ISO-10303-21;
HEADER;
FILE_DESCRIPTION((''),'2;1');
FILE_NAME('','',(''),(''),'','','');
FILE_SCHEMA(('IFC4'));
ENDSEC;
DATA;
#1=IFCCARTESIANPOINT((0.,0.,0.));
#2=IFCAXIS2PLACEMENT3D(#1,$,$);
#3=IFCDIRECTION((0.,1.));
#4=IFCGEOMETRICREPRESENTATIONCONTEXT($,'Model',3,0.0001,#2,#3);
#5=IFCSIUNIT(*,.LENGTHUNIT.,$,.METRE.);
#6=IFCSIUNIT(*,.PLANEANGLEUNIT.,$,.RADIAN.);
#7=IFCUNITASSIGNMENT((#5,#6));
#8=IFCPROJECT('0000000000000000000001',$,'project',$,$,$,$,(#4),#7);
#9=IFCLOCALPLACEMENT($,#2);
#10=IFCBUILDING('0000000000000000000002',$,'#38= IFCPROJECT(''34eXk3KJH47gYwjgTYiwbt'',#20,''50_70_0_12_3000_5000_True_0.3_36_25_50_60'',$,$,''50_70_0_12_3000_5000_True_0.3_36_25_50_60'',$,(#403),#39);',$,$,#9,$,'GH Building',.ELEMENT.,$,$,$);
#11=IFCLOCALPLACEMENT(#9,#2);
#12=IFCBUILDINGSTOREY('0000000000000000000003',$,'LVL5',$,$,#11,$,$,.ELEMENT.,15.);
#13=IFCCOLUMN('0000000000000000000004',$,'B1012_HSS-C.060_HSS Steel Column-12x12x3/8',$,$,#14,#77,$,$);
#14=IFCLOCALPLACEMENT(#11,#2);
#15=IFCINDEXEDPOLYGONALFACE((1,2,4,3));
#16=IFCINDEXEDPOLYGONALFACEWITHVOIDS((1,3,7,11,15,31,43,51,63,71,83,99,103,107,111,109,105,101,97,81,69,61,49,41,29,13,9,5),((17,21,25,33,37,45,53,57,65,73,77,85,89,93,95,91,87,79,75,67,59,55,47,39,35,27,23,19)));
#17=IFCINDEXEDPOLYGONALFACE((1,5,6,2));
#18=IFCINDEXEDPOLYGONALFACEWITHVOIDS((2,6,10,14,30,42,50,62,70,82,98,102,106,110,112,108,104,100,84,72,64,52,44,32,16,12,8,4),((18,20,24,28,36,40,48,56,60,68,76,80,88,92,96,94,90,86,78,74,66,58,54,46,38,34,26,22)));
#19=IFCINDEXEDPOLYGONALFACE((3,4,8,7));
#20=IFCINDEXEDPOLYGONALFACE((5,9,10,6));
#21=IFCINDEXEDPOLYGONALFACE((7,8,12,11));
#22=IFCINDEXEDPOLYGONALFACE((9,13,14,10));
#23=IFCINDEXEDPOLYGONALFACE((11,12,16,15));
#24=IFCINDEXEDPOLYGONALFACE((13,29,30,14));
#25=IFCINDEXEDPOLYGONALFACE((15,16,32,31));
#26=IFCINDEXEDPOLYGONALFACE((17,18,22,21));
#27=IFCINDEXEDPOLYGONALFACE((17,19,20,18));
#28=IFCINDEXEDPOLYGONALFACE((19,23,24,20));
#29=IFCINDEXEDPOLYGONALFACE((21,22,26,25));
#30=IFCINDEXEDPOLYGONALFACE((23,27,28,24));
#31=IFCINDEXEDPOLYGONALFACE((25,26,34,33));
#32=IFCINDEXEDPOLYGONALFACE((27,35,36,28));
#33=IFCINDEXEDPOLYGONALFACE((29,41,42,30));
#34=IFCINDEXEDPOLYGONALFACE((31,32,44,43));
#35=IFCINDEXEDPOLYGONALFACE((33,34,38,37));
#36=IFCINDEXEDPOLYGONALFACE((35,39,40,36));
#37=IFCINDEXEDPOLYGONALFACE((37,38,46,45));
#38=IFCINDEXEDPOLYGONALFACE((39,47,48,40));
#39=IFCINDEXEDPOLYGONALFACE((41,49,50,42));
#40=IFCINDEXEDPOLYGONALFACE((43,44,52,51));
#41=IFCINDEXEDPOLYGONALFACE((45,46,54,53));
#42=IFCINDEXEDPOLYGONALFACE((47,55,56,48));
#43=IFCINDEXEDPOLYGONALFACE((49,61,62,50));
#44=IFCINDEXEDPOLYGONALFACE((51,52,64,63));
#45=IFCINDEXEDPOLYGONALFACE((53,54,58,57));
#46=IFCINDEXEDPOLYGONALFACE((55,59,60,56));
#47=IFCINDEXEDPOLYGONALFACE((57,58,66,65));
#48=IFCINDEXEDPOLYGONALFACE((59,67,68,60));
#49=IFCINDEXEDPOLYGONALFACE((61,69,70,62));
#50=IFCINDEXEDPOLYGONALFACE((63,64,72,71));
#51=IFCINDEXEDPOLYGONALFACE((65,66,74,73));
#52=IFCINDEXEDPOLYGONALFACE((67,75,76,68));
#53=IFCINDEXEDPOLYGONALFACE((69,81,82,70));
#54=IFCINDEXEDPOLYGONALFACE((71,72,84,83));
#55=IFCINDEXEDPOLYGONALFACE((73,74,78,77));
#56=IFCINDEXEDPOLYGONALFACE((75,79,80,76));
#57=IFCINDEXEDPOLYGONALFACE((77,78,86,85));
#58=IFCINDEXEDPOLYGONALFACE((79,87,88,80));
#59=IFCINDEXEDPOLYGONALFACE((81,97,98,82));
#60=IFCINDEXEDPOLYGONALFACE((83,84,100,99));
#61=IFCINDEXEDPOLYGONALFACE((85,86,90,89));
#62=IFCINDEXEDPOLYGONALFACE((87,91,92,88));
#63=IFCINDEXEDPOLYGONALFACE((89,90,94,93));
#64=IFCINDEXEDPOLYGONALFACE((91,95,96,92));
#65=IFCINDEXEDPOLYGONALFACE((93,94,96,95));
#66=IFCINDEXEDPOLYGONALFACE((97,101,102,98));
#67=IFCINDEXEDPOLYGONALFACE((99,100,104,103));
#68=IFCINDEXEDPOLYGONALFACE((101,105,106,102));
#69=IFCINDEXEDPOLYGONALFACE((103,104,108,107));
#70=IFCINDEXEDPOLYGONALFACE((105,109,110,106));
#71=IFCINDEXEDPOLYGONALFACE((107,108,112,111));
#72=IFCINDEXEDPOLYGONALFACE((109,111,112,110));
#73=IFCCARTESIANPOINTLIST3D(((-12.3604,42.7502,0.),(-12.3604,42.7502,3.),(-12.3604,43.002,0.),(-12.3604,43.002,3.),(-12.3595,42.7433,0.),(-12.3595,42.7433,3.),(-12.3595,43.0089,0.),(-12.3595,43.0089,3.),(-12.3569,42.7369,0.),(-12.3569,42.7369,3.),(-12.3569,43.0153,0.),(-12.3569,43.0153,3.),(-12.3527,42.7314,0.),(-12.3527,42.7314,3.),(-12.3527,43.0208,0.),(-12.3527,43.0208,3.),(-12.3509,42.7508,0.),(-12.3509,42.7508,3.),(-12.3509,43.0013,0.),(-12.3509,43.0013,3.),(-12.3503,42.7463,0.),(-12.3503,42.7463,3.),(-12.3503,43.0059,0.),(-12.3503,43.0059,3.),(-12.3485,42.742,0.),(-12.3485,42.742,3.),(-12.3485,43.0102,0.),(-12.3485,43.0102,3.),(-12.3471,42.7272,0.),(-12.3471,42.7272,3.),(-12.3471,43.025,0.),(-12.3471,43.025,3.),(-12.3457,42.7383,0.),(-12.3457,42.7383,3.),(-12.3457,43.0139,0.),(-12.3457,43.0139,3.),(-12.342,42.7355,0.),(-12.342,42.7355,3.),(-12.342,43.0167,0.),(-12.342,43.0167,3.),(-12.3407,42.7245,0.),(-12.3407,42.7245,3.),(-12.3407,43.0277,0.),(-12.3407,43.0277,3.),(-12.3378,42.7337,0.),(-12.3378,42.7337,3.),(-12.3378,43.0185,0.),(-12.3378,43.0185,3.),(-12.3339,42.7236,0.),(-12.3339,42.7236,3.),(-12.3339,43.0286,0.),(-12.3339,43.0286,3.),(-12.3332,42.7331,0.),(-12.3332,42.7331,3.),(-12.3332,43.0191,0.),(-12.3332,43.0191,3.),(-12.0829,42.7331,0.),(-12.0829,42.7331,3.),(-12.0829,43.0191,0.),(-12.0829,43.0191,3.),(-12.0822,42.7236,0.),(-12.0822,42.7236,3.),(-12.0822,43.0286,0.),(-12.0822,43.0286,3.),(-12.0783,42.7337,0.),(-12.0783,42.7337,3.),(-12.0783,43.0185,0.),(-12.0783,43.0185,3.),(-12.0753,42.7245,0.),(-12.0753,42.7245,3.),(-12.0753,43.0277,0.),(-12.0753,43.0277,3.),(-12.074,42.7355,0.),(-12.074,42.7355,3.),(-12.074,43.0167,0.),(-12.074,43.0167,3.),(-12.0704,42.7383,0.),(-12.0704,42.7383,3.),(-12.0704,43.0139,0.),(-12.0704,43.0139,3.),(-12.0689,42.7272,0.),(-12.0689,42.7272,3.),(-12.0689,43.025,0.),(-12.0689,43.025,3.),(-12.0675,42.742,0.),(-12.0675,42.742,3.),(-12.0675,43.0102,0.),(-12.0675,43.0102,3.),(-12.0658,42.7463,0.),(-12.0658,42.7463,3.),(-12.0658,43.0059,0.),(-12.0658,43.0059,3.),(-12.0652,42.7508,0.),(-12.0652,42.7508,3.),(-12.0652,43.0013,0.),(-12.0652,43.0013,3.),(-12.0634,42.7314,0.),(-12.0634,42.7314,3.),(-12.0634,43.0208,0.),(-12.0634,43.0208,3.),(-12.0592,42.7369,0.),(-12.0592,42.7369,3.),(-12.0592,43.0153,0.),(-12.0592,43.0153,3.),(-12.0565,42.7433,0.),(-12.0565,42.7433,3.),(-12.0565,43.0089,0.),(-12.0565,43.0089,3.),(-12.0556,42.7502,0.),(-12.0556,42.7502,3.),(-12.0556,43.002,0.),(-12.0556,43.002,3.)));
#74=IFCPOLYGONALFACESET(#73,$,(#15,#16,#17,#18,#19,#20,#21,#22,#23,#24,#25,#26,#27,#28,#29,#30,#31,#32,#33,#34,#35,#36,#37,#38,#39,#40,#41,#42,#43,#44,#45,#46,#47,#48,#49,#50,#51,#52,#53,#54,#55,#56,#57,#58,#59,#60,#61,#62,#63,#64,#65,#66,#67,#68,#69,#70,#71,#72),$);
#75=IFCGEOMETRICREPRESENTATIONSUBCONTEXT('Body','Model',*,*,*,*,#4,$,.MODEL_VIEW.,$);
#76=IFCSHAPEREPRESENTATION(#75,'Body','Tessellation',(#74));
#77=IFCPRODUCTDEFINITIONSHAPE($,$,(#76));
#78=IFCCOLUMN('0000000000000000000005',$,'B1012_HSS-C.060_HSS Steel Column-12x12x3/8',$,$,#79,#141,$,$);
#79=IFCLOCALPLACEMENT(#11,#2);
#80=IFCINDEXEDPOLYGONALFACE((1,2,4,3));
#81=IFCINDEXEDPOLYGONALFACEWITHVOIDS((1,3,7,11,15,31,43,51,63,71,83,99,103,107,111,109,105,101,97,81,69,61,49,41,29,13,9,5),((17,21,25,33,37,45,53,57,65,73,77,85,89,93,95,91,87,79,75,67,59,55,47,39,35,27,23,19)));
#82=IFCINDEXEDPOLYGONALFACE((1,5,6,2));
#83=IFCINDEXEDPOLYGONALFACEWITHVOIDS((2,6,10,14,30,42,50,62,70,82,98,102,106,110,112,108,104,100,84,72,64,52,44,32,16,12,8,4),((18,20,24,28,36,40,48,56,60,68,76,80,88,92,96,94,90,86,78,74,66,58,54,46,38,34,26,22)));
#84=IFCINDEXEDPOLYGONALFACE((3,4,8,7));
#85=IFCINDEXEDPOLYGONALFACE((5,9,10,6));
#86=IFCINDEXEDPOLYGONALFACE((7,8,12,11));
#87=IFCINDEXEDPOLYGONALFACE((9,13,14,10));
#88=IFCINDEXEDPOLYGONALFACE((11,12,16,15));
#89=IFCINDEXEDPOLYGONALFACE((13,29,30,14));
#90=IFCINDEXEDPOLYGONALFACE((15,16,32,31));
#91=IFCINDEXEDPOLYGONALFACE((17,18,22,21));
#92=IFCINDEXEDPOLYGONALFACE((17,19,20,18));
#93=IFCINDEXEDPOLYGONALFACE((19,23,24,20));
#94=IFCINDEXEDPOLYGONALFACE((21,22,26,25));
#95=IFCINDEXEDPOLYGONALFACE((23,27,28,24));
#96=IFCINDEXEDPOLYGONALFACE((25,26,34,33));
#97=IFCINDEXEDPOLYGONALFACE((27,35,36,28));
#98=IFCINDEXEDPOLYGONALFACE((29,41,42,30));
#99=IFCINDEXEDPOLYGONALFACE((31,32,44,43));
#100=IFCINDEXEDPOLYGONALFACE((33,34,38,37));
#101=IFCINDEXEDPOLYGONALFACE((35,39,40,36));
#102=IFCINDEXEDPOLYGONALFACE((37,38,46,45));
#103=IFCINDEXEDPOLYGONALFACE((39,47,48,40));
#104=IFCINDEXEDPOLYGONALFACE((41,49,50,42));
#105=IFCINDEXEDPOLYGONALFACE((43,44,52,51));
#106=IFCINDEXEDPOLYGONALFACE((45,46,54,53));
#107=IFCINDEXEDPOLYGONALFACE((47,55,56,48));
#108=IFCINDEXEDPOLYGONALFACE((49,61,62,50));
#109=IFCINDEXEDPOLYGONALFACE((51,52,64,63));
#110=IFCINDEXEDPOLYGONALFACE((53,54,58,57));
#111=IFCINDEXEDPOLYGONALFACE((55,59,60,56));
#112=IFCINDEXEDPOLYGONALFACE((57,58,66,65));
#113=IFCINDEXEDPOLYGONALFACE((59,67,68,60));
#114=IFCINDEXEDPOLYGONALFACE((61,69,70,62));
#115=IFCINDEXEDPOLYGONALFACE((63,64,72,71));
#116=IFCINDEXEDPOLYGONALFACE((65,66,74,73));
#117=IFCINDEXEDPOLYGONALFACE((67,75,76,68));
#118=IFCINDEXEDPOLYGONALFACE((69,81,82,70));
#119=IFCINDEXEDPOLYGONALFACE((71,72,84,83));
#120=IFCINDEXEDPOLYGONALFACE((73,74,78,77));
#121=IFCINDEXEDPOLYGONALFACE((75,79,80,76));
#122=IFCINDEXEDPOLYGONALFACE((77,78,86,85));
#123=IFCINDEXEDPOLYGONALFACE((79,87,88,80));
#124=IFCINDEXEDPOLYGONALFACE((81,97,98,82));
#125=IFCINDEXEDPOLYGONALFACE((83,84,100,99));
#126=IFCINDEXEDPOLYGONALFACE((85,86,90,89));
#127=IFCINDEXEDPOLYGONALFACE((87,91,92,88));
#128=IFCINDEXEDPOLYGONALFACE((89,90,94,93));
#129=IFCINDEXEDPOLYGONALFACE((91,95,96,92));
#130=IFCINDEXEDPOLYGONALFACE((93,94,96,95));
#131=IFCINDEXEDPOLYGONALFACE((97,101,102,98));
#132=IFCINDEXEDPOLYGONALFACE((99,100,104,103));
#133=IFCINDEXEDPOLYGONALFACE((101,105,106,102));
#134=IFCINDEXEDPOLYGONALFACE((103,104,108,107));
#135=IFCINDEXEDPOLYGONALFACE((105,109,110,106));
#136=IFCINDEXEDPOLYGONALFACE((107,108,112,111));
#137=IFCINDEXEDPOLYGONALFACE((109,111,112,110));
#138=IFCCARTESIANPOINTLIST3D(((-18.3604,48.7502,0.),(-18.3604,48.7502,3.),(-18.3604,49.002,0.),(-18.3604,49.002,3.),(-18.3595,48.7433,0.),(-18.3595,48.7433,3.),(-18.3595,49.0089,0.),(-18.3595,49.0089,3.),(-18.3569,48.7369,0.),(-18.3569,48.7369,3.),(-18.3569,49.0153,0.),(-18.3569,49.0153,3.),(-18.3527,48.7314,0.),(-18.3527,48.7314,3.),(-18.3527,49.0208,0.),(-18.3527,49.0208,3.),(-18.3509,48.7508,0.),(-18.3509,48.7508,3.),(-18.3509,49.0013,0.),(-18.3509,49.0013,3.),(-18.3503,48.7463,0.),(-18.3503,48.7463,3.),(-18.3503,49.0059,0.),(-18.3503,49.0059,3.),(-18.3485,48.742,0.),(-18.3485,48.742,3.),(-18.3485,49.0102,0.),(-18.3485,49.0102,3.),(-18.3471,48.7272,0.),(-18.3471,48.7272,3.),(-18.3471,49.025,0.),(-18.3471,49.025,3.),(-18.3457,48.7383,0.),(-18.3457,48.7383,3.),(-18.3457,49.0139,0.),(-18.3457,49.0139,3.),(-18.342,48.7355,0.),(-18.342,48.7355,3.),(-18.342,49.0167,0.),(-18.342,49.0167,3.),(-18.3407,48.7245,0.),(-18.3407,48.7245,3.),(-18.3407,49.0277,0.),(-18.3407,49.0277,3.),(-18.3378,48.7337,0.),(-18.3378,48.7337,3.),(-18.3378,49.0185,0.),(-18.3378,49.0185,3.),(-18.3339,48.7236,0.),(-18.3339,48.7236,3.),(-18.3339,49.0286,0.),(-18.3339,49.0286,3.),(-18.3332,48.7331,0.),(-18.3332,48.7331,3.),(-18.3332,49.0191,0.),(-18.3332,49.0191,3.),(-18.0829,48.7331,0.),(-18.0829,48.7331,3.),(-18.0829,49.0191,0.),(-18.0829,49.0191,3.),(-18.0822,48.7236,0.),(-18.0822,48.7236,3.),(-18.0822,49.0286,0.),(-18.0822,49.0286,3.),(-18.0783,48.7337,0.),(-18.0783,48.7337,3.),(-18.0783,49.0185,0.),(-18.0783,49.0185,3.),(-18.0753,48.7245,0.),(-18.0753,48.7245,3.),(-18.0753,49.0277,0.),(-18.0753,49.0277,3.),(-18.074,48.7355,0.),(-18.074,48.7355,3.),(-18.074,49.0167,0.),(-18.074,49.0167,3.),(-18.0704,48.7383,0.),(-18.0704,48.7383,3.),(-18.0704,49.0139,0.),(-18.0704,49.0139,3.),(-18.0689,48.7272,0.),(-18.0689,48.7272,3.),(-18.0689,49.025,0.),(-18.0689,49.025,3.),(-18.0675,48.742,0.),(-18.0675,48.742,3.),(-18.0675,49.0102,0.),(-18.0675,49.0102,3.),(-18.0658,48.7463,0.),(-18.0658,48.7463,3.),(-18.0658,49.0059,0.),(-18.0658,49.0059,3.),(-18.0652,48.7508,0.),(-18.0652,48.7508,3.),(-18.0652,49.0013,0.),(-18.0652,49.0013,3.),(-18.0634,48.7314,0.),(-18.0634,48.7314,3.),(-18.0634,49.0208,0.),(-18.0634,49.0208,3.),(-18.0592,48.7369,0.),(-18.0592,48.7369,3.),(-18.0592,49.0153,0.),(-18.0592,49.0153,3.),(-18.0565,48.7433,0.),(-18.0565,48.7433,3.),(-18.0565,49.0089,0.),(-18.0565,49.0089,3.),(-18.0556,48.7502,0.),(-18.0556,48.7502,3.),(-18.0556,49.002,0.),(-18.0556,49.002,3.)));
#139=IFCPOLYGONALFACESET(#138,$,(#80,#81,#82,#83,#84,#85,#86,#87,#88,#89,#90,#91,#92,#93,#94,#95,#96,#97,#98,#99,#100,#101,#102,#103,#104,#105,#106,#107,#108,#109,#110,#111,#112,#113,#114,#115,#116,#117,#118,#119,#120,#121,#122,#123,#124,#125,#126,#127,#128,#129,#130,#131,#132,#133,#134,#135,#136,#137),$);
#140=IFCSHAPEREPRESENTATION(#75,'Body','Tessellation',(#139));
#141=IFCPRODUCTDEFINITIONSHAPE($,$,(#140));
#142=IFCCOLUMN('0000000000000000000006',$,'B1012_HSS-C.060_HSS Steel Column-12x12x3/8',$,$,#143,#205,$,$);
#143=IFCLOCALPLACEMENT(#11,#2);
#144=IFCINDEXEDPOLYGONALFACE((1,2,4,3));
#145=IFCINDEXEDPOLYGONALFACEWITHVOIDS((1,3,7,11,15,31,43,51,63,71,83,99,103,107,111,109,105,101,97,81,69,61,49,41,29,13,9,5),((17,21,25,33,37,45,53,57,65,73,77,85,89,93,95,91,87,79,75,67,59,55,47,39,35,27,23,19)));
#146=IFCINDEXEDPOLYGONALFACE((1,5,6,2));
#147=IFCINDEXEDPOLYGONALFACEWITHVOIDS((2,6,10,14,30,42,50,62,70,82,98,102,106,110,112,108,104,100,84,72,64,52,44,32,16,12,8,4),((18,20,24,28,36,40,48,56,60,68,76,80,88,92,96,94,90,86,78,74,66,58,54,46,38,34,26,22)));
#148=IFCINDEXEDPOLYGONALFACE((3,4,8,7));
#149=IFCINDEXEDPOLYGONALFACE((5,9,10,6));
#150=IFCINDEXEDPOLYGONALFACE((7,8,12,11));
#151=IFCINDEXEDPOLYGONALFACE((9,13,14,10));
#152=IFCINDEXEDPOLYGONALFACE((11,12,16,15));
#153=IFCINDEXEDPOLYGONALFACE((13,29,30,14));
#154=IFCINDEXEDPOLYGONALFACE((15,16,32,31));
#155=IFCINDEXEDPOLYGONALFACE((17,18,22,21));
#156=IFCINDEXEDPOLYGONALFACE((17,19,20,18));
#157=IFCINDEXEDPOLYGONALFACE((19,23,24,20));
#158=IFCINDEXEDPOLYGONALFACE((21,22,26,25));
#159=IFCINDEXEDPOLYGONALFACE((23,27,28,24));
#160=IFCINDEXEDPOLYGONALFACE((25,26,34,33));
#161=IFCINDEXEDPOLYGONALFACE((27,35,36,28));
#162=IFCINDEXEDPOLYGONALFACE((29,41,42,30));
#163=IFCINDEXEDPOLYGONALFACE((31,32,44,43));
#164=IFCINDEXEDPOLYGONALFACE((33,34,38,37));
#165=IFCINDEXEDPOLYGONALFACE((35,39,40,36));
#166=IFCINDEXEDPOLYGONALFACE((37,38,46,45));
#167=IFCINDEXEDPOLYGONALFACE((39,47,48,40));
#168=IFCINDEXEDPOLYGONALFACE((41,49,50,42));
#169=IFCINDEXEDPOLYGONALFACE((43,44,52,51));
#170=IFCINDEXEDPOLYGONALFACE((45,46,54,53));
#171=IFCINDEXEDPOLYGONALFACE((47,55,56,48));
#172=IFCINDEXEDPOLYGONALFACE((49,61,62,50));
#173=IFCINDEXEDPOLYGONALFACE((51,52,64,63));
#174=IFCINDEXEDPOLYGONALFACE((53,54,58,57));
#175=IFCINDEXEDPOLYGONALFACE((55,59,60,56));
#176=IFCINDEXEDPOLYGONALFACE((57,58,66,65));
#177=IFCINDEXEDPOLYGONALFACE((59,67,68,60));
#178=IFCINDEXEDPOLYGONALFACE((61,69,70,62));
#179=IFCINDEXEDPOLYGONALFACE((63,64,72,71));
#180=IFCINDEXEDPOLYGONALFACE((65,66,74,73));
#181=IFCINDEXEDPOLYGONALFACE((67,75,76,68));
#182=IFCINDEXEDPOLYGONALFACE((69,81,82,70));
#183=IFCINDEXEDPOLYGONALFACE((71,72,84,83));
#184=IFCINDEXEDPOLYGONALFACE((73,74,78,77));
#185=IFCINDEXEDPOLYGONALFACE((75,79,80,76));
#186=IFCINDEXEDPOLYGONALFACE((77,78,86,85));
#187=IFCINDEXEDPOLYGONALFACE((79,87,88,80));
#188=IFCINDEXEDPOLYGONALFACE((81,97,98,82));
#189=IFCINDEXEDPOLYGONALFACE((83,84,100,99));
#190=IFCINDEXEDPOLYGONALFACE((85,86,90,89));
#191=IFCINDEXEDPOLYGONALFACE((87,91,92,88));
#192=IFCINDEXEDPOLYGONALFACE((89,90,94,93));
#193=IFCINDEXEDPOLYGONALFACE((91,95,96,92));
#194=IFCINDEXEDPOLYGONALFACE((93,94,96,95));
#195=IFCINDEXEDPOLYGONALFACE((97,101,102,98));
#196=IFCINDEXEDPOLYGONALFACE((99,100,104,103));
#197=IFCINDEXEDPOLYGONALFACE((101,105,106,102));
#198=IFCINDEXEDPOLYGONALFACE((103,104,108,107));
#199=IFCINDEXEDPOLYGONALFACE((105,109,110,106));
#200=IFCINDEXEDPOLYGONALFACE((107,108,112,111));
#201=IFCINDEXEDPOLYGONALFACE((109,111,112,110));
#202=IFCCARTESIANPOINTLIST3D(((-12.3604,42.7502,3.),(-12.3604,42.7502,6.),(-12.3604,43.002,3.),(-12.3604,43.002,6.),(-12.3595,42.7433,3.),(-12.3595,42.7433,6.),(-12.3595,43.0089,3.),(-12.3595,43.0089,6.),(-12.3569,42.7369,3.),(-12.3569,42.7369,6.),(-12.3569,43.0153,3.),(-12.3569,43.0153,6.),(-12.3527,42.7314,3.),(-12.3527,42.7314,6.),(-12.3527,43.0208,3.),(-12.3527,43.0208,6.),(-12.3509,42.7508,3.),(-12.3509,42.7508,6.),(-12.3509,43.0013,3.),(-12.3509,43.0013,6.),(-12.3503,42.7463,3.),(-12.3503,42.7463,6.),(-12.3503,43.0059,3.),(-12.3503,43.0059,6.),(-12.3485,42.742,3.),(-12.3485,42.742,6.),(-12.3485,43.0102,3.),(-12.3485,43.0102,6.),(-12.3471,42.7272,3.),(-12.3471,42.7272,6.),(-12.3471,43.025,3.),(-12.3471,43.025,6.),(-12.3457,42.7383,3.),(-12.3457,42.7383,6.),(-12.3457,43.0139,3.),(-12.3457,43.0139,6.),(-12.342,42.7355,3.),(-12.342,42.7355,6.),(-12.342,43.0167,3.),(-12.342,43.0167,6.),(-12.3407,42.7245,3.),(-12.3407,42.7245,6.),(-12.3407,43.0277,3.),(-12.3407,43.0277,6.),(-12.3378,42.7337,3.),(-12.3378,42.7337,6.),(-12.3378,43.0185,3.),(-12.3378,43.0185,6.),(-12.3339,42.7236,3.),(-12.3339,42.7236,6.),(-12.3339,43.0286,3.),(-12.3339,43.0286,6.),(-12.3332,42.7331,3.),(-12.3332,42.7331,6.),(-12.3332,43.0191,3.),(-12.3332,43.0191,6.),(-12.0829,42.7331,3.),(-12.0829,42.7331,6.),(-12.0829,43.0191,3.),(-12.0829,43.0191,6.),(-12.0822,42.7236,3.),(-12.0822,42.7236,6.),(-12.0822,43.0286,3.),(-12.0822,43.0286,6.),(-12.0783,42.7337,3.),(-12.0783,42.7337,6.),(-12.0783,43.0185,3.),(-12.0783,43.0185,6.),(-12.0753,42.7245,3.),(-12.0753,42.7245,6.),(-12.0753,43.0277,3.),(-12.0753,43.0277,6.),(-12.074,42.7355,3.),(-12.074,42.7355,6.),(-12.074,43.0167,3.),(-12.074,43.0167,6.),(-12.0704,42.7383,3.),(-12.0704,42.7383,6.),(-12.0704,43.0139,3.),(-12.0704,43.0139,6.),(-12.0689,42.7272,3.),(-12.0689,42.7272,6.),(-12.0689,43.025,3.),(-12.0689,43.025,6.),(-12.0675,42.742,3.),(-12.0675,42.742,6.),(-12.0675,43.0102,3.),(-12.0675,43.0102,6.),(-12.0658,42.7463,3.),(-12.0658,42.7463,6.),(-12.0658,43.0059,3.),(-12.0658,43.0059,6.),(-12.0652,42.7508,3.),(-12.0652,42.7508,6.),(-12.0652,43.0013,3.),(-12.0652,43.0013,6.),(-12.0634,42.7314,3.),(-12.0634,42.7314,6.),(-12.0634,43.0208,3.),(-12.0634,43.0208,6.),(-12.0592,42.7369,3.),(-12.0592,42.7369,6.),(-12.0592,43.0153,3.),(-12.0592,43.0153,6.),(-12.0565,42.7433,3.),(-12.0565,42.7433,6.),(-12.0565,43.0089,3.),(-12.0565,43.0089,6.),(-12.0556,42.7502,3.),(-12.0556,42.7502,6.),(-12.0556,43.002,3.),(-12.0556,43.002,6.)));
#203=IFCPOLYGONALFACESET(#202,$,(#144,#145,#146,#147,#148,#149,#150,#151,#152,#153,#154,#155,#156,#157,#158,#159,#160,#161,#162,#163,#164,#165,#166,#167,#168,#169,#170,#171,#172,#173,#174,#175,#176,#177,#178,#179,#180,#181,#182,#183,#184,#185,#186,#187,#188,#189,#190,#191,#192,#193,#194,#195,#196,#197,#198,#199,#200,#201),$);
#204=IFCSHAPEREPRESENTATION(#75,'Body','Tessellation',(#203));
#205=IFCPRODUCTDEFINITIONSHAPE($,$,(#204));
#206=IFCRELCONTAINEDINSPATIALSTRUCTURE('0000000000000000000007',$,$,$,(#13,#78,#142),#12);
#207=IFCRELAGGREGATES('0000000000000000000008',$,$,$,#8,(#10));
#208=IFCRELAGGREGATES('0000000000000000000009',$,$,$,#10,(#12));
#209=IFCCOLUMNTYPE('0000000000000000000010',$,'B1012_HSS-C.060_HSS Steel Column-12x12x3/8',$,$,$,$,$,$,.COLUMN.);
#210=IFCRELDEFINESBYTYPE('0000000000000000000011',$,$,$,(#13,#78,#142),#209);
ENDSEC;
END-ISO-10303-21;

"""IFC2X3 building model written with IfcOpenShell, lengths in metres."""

from ifc_helpers import new_model, si_unit, direction, frame, origin, origin_2d, place, context, subcontext, project, spatial, hollow_rectangle, extrude, type_object, element, save


model = new_model("IFC2X3")

# Units and contexts
model_context = context("Model", 3, precision=0.0001, world=origin(), true_north=direction((0.0, 1.0)))
body_context = subcontext(model_context, "Body", "Model", "MODEL_VIEW")
ifc_project = project(units=[si_unit("LENGTHUNIT", "METRE"), si_unit("PLANEANGLEUNIT", "RADIAN")], contexts=[model_context])

# Building, storey
building_placement = place(None, origin())
building = spatial("IfcBuilding", under=ifc_project, at=building_placement, Name="#38= IFCPROJECT('34eXk3KJH47gYwjgTYiwbt',#20,'50_70_0_12_3000_5000_True_0.3_36_25_50_60',$,$,'50_70_0_12_3000_5000_True_0.3_36_25_50_60',$,(#403),#39);", LongName="GH Building", CompositionType="ELEMENT")
storey_placement = place(building_placement, origin())
storey = spatial("IfcBuildingStorey", under=building, at=storey_placement, Name="LVL5", CompositionType="ELEMENT", Elevation=15.0)

# Columns
column_type = type_object("IfcColumnType", Name="B1012_HSS-C.060_HSS Steel Column-12x12x3/8", PredefinedType="COLUMN")
for number, where, z_axis, x_axis, name in (
    (1, (-12.208, 42.8761, 3.0), (0.0, 0.0, -1.0), (-1.0, 0.0, 0.0), "B1012_HSS-C.060_HSS Steel Column-12x12x3/8"),
    (2, (-18.208, 48.8761, 3.0), (0.0, 0.0, -1.0), (-1.0, 0.0, 0.0), "B1012_HSS-C.060_HSS Steel Column-12x12x3/8"),
    (3, (-12.208, 42.8761, 6.0), (0.0, 0.0, -1.0), (-1.0, 0.0, 0.0), "B1012_HSS-C.060_HSS Steel Column-12x12x3/8"),
):
    element("IfcColumn", number, at=place(storey_placement, frame(where, z_axis=z_axis, x_axis=x_axis)), inside=storey, type_object=column_type, Name=name, context=body_context, shape_type="SweptSolid", body=[
        extrude(hollow_rectangle(XDim=0.3048, YDim=0.305, WallThickness=0.0095, InnerFilletRadius=0.0177, OuterFilletRadius=0.0266, at=origin_2d()), origin(), (0.0, 0.0, 1.0), 3.0),
    ])

save(model, "model.ifc")
